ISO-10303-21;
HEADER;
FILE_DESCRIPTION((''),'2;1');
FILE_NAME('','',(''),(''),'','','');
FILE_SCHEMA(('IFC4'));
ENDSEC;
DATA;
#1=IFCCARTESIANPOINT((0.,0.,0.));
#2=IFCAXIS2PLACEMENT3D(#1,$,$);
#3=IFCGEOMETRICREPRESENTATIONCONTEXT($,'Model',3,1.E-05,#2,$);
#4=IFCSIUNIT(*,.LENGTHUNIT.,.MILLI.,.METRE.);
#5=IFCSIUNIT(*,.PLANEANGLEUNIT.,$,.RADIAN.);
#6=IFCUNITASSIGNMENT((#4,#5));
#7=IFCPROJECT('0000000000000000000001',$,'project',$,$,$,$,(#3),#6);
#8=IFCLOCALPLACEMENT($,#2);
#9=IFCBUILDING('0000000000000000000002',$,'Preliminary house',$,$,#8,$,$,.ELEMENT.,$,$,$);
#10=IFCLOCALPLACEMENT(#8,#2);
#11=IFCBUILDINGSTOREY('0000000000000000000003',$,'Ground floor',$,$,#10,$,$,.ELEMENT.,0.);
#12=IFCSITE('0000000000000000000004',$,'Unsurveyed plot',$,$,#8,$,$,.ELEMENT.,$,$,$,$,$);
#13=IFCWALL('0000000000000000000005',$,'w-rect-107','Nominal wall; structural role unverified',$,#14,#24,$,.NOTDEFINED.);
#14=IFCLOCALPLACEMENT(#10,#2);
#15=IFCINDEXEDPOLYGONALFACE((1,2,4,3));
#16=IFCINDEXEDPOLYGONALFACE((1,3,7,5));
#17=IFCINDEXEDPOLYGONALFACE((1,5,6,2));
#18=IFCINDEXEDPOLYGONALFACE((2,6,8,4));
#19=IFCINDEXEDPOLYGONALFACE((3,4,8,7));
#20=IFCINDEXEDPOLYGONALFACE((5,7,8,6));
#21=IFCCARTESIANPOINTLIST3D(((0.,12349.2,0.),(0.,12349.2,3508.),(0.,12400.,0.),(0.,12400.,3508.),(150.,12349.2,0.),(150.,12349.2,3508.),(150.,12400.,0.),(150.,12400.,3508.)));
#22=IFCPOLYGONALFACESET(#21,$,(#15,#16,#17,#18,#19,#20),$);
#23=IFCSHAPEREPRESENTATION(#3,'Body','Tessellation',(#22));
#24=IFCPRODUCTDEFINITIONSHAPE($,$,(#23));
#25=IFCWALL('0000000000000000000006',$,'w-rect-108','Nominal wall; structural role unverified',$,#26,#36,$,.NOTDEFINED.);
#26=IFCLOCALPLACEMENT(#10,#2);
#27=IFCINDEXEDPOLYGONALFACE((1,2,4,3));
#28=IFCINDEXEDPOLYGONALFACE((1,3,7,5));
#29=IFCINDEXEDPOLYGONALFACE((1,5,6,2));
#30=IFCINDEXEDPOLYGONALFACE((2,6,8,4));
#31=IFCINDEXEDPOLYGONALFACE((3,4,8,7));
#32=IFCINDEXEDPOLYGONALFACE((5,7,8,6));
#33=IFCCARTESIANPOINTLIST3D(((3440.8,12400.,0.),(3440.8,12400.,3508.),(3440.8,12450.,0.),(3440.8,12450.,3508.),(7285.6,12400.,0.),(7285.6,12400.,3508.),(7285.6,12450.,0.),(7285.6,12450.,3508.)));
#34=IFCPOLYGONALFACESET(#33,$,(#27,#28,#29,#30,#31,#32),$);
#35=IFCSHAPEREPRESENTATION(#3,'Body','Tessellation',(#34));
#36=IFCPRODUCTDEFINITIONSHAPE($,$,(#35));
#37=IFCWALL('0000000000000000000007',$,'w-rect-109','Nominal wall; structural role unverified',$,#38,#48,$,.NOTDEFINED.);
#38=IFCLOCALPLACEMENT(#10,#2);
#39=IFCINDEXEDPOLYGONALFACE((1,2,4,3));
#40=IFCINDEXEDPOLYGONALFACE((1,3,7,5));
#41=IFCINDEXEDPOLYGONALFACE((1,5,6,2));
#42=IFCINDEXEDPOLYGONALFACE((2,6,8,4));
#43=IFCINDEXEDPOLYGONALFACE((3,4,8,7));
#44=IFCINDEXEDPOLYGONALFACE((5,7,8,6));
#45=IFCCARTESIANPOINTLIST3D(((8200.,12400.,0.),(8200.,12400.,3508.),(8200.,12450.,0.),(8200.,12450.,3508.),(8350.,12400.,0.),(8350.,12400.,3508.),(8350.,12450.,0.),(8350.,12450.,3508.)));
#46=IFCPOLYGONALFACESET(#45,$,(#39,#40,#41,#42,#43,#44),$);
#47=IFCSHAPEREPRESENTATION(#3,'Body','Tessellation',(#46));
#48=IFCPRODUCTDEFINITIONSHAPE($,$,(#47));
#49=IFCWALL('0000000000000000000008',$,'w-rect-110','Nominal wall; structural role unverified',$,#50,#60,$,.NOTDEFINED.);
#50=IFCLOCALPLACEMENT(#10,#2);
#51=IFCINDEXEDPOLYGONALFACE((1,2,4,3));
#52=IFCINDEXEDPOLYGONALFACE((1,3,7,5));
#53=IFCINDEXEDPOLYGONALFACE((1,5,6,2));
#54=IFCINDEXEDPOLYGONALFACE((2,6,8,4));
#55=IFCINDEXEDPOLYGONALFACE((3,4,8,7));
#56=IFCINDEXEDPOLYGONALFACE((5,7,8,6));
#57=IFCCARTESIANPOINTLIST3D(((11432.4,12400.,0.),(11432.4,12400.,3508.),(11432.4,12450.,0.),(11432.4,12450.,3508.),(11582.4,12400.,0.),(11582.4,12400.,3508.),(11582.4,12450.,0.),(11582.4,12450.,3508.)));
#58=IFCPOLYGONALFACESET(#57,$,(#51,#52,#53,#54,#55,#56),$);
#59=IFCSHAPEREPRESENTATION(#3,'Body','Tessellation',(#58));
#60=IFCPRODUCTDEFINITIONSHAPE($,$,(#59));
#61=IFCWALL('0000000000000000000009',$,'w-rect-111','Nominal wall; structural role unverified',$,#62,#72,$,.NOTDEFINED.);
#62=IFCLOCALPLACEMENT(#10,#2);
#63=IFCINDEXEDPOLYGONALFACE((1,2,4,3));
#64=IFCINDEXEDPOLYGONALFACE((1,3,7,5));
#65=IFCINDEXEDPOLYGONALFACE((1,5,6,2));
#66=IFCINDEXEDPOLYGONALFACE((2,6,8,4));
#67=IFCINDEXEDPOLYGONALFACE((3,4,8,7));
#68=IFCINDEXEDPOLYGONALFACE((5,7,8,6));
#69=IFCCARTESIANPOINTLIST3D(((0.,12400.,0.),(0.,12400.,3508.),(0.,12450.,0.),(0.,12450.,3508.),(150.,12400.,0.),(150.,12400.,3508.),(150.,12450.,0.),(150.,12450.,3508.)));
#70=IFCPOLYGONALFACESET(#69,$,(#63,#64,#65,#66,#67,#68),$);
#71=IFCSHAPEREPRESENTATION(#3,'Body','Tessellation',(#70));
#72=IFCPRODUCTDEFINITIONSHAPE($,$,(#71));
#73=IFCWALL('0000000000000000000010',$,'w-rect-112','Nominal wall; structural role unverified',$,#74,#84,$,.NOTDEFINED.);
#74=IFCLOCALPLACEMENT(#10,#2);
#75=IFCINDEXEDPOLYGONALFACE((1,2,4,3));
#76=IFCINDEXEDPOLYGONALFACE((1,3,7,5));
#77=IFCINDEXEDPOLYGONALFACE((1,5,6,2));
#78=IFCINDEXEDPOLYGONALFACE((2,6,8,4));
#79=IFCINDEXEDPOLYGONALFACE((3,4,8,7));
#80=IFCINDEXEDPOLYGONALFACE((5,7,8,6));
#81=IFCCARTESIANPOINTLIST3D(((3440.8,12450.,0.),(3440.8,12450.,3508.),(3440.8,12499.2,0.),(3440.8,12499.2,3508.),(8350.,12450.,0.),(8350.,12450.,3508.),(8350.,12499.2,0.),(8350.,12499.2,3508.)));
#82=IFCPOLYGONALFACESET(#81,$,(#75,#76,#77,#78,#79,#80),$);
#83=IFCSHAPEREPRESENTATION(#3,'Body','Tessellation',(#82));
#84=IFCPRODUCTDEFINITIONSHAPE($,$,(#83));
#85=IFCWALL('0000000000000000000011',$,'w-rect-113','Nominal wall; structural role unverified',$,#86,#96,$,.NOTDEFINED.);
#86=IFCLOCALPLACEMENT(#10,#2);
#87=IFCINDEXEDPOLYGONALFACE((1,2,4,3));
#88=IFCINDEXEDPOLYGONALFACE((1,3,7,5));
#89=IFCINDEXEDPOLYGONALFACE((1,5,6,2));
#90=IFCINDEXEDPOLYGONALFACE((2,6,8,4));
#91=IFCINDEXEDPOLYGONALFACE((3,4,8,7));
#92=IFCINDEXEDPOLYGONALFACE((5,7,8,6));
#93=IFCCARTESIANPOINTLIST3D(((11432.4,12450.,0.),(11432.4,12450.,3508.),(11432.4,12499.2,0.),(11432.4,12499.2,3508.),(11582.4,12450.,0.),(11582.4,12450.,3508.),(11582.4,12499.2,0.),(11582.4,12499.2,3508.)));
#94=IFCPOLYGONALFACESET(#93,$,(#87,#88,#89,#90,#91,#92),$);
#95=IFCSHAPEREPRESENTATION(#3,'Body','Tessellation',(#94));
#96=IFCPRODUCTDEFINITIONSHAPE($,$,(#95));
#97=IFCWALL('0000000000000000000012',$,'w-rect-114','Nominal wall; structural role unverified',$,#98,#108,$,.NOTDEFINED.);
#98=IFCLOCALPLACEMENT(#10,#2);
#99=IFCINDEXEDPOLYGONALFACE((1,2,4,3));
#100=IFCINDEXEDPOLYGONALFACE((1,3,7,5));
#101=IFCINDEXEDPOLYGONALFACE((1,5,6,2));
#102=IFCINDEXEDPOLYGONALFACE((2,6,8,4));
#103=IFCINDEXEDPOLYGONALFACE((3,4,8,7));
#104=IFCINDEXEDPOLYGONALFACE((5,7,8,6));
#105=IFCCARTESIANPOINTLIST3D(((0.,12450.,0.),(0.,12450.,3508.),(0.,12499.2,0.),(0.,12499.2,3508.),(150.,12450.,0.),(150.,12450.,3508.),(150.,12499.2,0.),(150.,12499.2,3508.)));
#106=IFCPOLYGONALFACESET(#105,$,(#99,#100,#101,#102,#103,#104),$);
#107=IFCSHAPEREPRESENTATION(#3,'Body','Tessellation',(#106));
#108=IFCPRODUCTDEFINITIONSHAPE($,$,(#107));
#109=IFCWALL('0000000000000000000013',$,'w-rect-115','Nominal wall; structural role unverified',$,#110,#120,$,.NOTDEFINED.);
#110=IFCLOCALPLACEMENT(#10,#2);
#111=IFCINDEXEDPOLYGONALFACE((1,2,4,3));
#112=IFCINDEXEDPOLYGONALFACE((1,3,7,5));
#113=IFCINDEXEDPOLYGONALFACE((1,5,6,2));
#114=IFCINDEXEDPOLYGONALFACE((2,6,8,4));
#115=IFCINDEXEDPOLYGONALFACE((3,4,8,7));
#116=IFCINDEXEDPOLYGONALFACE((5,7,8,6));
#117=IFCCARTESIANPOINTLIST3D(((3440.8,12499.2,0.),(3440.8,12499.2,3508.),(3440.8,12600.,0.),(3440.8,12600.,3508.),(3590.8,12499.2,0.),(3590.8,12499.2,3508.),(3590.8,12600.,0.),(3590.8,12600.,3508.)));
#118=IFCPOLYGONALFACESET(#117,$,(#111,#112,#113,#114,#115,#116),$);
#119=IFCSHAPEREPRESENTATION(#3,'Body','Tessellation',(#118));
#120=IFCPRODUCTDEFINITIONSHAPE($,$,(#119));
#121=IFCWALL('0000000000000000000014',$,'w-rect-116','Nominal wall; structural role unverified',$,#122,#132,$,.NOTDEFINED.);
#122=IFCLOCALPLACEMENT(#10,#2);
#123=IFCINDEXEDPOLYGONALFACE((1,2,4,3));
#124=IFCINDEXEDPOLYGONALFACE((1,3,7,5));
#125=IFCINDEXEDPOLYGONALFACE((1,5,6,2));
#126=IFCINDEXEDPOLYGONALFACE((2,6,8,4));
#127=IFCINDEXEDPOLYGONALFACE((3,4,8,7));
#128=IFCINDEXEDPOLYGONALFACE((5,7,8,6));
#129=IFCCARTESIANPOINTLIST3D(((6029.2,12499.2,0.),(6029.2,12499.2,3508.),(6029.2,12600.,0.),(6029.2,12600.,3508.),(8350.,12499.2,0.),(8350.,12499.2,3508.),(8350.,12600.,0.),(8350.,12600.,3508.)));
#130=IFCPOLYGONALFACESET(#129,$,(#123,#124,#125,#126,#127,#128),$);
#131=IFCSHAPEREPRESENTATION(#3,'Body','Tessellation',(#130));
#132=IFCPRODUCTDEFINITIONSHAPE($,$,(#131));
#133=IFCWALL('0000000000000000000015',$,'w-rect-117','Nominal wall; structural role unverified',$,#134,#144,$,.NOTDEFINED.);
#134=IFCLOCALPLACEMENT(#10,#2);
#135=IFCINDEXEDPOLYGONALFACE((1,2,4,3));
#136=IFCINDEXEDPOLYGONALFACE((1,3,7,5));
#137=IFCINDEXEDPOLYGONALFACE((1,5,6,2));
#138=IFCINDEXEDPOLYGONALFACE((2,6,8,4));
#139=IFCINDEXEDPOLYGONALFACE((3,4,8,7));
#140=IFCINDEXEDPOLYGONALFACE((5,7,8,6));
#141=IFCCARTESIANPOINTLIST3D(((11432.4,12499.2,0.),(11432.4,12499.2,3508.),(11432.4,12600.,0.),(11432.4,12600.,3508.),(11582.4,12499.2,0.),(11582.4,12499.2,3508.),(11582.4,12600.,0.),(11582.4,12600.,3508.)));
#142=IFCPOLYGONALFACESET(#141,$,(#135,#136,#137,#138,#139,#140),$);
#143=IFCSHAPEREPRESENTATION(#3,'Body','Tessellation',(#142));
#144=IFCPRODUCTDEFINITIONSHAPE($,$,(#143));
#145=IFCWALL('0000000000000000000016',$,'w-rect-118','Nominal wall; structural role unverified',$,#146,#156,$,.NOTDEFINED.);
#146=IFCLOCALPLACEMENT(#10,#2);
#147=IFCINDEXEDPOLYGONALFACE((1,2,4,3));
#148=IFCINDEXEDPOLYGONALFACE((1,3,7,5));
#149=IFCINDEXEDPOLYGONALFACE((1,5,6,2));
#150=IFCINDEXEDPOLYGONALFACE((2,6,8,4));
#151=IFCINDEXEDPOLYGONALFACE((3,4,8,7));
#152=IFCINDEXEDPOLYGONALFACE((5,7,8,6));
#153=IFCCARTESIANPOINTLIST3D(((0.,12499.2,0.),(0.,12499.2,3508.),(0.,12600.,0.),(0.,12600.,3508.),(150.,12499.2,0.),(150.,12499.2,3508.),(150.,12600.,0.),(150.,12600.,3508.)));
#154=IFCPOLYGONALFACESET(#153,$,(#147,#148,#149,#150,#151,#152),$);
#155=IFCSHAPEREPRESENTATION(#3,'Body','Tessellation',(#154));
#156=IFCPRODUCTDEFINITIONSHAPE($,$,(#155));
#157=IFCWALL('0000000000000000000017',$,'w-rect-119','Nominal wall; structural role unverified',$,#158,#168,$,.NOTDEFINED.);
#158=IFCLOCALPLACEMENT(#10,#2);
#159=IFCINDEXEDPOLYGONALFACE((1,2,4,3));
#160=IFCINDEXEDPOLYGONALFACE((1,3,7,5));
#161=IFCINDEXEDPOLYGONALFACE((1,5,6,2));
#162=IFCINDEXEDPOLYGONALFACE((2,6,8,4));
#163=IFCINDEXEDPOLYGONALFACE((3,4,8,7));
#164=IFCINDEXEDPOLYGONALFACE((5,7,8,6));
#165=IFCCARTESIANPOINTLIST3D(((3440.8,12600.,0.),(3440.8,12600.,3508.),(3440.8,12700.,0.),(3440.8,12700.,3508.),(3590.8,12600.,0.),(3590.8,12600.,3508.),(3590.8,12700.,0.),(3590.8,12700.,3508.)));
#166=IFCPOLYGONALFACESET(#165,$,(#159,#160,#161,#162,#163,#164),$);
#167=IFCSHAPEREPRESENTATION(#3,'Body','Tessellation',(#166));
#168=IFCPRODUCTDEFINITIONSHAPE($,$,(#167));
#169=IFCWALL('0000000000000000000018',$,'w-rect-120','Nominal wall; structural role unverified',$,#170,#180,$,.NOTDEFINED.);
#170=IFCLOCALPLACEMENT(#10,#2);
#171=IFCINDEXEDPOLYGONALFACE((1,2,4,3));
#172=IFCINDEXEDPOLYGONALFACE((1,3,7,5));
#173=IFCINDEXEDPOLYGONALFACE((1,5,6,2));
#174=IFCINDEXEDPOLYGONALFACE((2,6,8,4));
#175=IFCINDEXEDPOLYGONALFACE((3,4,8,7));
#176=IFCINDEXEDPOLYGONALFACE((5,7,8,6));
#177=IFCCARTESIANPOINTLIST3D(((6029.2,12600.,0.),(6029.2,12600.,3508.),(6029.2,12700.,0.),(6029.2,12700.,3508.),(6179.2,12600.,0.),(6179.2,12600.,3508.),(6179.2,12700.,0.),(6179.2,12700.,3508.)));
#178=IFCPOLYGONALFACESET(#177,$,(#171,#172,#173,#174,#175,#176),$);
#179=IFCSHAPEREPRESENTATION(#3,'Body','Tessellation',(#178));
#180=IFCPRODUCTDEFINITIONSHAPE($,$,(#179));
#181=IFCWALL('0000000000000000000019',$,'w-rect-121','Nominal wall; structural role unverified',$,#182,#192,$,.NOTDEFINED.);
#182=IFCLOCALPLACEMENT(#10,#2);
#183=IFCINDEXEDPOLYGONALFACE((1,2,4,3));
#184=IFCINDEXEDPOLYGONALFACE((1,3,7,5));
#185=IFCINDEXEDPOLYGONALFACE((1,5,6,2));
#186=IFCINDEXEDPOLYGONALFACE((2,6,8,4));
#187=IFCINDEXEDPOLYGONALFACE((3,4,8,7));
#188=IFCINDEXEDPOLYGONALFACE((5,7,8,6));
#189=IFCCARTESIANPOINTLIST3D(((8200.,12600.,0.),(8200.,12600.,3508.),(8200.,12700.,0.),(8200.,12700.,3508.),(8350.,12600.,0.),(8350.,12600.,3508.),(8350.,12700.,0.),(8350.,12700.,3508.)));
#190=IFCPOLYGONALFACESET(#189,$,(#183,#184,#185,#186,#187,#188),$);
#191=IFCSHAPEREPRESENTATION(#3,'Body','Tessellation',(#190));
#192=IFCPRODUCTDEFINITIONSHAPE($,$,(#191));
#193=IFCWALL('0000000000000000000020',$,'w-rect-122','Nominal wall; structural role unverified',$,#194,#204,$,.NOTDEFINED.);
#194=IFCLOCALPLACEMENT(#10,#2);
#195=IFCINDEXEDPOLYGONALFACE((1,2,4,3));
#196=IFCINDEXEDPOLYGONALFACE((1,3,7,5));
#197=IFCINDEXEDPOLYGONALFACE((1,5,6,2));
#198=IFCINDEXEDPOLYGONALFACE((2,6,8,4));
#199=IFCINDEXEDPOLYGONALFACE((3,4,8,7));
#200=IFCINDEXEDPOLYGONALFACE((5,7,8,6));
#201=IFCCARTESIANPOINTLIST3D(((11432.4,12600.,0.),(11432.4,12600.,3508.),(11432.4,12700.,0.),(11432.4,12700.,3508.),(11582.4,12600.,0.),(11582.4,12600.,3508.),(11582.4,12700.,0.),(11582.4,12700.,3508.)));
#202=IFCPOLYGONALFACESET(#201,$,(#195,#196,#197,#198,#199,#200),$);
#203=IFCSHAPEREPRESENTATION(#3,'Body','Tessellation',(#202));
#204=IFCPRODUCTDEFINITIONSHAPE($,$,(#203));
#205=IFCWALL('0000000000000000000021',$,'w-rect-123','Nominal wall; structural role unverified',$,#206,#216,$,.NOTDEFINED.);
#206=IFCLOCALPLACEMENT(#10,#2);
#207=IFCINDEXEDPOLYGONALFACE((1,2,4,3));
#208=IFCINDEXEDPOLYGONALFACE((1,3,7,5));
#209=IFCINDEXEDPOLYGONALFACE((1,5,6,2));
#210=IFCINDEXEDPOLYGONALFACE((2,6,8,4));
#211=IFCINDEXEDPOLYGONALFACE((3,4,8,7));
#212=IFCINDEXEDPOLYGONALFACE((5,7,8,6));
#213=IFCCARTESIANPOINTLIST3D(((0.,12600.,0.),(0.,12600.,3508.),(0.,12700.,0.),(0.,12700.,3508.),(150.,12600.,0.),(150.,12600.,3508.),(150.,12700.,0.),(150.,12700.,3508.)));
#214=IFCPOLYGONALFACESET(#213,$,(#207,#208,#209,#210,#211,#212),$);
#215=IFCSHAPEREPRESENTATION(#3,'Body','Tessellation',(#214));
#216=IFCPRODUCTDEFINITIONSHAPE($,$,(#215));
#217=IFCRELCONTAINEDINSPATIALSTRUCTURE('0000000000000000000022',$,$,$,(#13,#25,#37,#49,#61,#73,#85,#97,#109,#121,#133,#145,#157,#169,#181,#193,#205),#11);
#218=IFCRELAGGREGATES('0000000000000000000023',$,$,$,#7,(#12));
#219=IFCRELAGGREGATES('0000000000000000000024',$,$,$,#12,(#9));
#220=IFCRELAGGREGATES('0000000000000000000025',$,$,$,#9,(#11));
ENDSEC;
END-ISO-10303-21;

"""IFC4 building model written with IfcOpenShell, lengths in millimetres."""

from ifc_helpers import new_model, si_unit, origin, place, context, project, spatial, polyline, outline, extrude, element, save


model = new_model("IFC4")

# Units and contexts
model_context = context("Model", 3, precision=1e-05, world=origin())
ifc_project = project(units=[si_unit("LENGTHUNIT", "METRE", prefix="MILLI"), si_unit("PLANEANGLEUNIT", "RADIAN")], contexts=[model_context])

# Site, building, storey
placement_1 = place(None, origin())
site = spatial("IfcSite", under=ifc_project, at=placement_1, Name="Unsurveyed plot", CompositionType="ELEMENT")
building = spatial("IfcBuilding", under=site, at=placement_1, Name="Preliminary house", CompositionType="ELEMENT")
placement_2 = place(placement_1, origin())
storey = spatial("IfcBuildingStorey", under=building, at=placement_2, Name="Ground floor", CompositionType="ELEMENT", Elevation=0.0)

# Walls
element("IfcWall", 1, at=placement_2, inside=storey, Name="w-rect-107", Description="Nominal wall; structural role unverified", PredefinedType="NOTDEFINED", context=model_context, shape_type="SweptSolid", body=[
    extrude(outline(polyline([(0.0, 12349.2), (150.0, 12349.2), (150.0, 12400.0), (0.0, 12400.0), (0.0, 12349.2)])), origin(), (0.0, 0.0, 1.0), 3508.0),
])
element("IfcWall", 2, at=placement_2, inside=storey, Name="w-rect-108", Description="Nominal wall; structural role unverified", PredefinedType="NOTDEFINED", context=model_context, shape_type="SweptSolid", body=[
    extrude(outline(polyline([(3440.8, 12400.0), (7285.6, 12400.0), (7285.6, 12450.0), (3440.8, 12450.0), (3440.8, 12400.0)])), origin(), (0.0, 0.0, 1.0), 3508.0),
])
element("IfcWall", 3, at=placement_2, inside=storey, Name="w-rect-109", Description="Nominal wall; structural role unverified", PredefinedType="NOTDEFINED", context=model_context, shape_type="SweptSolid", body=[
    extrude(outline(polyline([(8200.0, 12400.0), (8350.0, 12400.0), (8350.0, 12450.0), (8200.0, 12450.0), (8200.0, 12400.0)])), origin(), (0.0, 0.0, 1.0), 3508.0),
])
element("IfcWall", 4, at=placement_2, inside=storey, Name="w-rect-110", Description="Nominal wall; structural role unverified", PredefinedType="NOTDEFINED", context=model_context, shape_type="SweptSolid", body=[
    extrude(outline(polyline([(11432.4, 12400.0), (11582.4, 12400.0), (11582.4, 12450.0), (11432.4, 12450.0), (11432.4, 12400.0)])), origin(), (0.0, 0.0, 1.0), 3508.0),
])
element("IfcWall", 5, at=placement_2, inside=storey, Name="w-rect-111", Description="Nominal wall; structural role unverified", PredefinedType="NOTDEFINED", context=model_context, shape_type="SweptSolid", body=[
    extrude(outline(polyline([(0.0, 12400.0), (150.0, 12400.0), (150.0, 12450.0), (0.0, 12450.0), (0.0, 12400.0)])), origin(), (0.0, 0.0, 1.0), 3508.0),
])
element("IfcWall", 6, at=placement_2, inside=storey, Name="w-rect-112", Description="Nominal wall; structural role unverified", PredefinedType="NOTDEFINED", context=model_context, shape_type="SweptSolid", body=[
    extrude(outline(polyline([(3440.8, 12450.0), (8350.0, 12450.0), (8350.0, 12499.2), (3440.8, 12499.2), (3440.8, 12450.0)])), origin(), (0.0, 0.0, 1.0), 3508.0),
])
element("IfcWall", 7, at=placement_2, inside=storey, Name="w-rect-113", Description="Nominal wall; structural role unverified", PredefinedType="NOTDEFINED", context=model_context, shape_type="SweptSolid", body=[
    extrude(outline(polyline([(11432.4, 12450.0), (11582.4, 12450.0), (11582.4, 12499.2), (11432.4, 12499.2), (11432.4, 12450.0)])), origin(), (0.0, 0.0, 1.0), 3508.0),
])
element("IfcWall", 8, at=placement_2, inside=storey, Name="w-rect-114", Description="Nominal wall; structural role unverified", PredefinedType="NOTDEFINED", context=model_context, shape_type="SweptSolid", body=[
    extrude(outline(polyline([(0.0, 12450.0), (150.0, 12450.0), (150.0, 12499.2), (0.0, 12499.2), (0.0, 12450.0)])), origin(), (0.0, 0.0, 1.0), 3508.0),
])
element("IfcWall", 9, at=placement_2, inside=storey, Name="w-rect-115", Description="Nominal wall; structural role unverified", PredefinedType="NOTDEFINED", context=model_context, shape_type="SweptSolid", body=[
    extrude(outline(polyline([(3440.8, 12499.2), (3590.8, 12499.2), (3590.8, 12600.0), (3440.8, 12600.0), (3440.8, 12499.2)])), origin(), (0.0, 0.0, 1.0), 3508.0),
])
element("IfcWall", 10, at=placement_2, inside=storey, Name="w-rect-116", Description="Nominal wall; structural role unverified", PredefinedType="NOTDEFINED", context=model_context, shape_type="SweptSolid", body=[
    extrude(outline(polyline([(6029.2, 12499.2), (8350.0, 12499.2), (8350.0, 12600.0), (6029.2, 12600.0), (6029.2, 12499.2)])), origin(), (0.0, 0.0, 1.0), 3508.0),
])
element("IfcWall", 11, at=placement_2, inside=storey, Name="w-rect-117", Description="Nominal wall; structural role unverified", PredefinedType="NOTDEFINED", context=model_context, shape_type="SweptSolid", body=[
    extrude(outline(polyline([(11432.4, 12499.2), (11582.4, 12499.2), (11582.4, 12600.0), (11432.4, 12600.0), (11432.4, 12499.2)])), origin(), (0.0, 0.0, 1.0), 3508.0),
])
element("IfcWall", 12, at=placement_2, inside=storey, Name="w-rect-118", Description="Nominal wall; structural role unverified", PredefinedType="NOTDEFINED", context=model_context, shape_type="SweptSolid", body=[
    extrude(outline(polyline([(0.0, 12499.2), (150.0, 12499.2), (150.0, 12600.0), (0.0, 12600.0), (0.0, 12499.2)])), origin(), (0.0, 0.0, 1.0), 3508.0),
])
element("IfcWall", 13, at=placement_2, inside=storey, Name="w-rect-119", Description="Nominal wall; structural role unverified", PredefinedType="NOTDEFINED", context=model_context, shape_type="SweptSolid", body=[
    extrude(outline(polyline([(3440.8, 12600.0), (3590.8, 12600.0), (3590.8, 12700.0), (3440.8, 12700.0), (3440.8, 12600.0)])), origin(), (0.0, 0.0, 1.0), 3508.0),
])
element("IfcWall", 14, at=placement_2, inside=storey, Name="w-rect-120", Description="Nominal wall; structural role unverified", PredefinedType="NOTDEFINED", context=model_context, shape_type="SweptSolid", body=[
    extrude(outline(polyline([(6029.2, 12600.0), (6179.2, 12600.0), (6179.2, 12700.0), (6029.2, 12700.0), (6029.2, 12600.0)])), origin(), (0.0, 0.0, 1.0), 3508.0),
])
element("IfcWall", 15, at=placement_2, inside=storey, Name="w-rect-121", Description="Nominal wall; structural role unverified", PredefinedType="NOTDEFINED", context=model_context, shape_type="SweptSolid", body=[
    extrude(outline(polyline([(8200.0, 12600.0), (8350.0, 12600.0), (8350.0, 12700.0), (8200.0, 12700.0), (8200.0, 12600.0)])), origin(), (0.0, 0.0, 1.0), 3508.0),
])
element("IfcWall", 16, at=placement_2, inside=storey, Name="w-rect-122", Description="Nominal wall; structural role unverified", PredefinedType="NOTDEFINED", context=model_context, shape_type="SweptSolid", body=[
    extrude(outline(polyline([(11432.4, 12600.0), (11582.4, 12600.0), (11582.4, 12700.0), (11432.4, 12700.0), (11432.4, 12600.0)])), origin(), (0.0, 0.0, 1.0), 3508.0),
])
element("IfcWall", 17, at=placement_2, inside=storey, Name="w-rect-123", Description="Nominal wall; structural role unverified", PredefinedType="NOTDEFINED", context=model_context, shape_type="SweptSolid", body=[
    extrude(outline(polyline([(0.0, 12600.0), (150.0, 12600.0), (150.0, 12700.0), (0.0, 12700.0), (0.0, 12600.0)])), origin(), (0.0, 0.0, 1.0), 3508.0),
])

save(model, "model.ifc")
